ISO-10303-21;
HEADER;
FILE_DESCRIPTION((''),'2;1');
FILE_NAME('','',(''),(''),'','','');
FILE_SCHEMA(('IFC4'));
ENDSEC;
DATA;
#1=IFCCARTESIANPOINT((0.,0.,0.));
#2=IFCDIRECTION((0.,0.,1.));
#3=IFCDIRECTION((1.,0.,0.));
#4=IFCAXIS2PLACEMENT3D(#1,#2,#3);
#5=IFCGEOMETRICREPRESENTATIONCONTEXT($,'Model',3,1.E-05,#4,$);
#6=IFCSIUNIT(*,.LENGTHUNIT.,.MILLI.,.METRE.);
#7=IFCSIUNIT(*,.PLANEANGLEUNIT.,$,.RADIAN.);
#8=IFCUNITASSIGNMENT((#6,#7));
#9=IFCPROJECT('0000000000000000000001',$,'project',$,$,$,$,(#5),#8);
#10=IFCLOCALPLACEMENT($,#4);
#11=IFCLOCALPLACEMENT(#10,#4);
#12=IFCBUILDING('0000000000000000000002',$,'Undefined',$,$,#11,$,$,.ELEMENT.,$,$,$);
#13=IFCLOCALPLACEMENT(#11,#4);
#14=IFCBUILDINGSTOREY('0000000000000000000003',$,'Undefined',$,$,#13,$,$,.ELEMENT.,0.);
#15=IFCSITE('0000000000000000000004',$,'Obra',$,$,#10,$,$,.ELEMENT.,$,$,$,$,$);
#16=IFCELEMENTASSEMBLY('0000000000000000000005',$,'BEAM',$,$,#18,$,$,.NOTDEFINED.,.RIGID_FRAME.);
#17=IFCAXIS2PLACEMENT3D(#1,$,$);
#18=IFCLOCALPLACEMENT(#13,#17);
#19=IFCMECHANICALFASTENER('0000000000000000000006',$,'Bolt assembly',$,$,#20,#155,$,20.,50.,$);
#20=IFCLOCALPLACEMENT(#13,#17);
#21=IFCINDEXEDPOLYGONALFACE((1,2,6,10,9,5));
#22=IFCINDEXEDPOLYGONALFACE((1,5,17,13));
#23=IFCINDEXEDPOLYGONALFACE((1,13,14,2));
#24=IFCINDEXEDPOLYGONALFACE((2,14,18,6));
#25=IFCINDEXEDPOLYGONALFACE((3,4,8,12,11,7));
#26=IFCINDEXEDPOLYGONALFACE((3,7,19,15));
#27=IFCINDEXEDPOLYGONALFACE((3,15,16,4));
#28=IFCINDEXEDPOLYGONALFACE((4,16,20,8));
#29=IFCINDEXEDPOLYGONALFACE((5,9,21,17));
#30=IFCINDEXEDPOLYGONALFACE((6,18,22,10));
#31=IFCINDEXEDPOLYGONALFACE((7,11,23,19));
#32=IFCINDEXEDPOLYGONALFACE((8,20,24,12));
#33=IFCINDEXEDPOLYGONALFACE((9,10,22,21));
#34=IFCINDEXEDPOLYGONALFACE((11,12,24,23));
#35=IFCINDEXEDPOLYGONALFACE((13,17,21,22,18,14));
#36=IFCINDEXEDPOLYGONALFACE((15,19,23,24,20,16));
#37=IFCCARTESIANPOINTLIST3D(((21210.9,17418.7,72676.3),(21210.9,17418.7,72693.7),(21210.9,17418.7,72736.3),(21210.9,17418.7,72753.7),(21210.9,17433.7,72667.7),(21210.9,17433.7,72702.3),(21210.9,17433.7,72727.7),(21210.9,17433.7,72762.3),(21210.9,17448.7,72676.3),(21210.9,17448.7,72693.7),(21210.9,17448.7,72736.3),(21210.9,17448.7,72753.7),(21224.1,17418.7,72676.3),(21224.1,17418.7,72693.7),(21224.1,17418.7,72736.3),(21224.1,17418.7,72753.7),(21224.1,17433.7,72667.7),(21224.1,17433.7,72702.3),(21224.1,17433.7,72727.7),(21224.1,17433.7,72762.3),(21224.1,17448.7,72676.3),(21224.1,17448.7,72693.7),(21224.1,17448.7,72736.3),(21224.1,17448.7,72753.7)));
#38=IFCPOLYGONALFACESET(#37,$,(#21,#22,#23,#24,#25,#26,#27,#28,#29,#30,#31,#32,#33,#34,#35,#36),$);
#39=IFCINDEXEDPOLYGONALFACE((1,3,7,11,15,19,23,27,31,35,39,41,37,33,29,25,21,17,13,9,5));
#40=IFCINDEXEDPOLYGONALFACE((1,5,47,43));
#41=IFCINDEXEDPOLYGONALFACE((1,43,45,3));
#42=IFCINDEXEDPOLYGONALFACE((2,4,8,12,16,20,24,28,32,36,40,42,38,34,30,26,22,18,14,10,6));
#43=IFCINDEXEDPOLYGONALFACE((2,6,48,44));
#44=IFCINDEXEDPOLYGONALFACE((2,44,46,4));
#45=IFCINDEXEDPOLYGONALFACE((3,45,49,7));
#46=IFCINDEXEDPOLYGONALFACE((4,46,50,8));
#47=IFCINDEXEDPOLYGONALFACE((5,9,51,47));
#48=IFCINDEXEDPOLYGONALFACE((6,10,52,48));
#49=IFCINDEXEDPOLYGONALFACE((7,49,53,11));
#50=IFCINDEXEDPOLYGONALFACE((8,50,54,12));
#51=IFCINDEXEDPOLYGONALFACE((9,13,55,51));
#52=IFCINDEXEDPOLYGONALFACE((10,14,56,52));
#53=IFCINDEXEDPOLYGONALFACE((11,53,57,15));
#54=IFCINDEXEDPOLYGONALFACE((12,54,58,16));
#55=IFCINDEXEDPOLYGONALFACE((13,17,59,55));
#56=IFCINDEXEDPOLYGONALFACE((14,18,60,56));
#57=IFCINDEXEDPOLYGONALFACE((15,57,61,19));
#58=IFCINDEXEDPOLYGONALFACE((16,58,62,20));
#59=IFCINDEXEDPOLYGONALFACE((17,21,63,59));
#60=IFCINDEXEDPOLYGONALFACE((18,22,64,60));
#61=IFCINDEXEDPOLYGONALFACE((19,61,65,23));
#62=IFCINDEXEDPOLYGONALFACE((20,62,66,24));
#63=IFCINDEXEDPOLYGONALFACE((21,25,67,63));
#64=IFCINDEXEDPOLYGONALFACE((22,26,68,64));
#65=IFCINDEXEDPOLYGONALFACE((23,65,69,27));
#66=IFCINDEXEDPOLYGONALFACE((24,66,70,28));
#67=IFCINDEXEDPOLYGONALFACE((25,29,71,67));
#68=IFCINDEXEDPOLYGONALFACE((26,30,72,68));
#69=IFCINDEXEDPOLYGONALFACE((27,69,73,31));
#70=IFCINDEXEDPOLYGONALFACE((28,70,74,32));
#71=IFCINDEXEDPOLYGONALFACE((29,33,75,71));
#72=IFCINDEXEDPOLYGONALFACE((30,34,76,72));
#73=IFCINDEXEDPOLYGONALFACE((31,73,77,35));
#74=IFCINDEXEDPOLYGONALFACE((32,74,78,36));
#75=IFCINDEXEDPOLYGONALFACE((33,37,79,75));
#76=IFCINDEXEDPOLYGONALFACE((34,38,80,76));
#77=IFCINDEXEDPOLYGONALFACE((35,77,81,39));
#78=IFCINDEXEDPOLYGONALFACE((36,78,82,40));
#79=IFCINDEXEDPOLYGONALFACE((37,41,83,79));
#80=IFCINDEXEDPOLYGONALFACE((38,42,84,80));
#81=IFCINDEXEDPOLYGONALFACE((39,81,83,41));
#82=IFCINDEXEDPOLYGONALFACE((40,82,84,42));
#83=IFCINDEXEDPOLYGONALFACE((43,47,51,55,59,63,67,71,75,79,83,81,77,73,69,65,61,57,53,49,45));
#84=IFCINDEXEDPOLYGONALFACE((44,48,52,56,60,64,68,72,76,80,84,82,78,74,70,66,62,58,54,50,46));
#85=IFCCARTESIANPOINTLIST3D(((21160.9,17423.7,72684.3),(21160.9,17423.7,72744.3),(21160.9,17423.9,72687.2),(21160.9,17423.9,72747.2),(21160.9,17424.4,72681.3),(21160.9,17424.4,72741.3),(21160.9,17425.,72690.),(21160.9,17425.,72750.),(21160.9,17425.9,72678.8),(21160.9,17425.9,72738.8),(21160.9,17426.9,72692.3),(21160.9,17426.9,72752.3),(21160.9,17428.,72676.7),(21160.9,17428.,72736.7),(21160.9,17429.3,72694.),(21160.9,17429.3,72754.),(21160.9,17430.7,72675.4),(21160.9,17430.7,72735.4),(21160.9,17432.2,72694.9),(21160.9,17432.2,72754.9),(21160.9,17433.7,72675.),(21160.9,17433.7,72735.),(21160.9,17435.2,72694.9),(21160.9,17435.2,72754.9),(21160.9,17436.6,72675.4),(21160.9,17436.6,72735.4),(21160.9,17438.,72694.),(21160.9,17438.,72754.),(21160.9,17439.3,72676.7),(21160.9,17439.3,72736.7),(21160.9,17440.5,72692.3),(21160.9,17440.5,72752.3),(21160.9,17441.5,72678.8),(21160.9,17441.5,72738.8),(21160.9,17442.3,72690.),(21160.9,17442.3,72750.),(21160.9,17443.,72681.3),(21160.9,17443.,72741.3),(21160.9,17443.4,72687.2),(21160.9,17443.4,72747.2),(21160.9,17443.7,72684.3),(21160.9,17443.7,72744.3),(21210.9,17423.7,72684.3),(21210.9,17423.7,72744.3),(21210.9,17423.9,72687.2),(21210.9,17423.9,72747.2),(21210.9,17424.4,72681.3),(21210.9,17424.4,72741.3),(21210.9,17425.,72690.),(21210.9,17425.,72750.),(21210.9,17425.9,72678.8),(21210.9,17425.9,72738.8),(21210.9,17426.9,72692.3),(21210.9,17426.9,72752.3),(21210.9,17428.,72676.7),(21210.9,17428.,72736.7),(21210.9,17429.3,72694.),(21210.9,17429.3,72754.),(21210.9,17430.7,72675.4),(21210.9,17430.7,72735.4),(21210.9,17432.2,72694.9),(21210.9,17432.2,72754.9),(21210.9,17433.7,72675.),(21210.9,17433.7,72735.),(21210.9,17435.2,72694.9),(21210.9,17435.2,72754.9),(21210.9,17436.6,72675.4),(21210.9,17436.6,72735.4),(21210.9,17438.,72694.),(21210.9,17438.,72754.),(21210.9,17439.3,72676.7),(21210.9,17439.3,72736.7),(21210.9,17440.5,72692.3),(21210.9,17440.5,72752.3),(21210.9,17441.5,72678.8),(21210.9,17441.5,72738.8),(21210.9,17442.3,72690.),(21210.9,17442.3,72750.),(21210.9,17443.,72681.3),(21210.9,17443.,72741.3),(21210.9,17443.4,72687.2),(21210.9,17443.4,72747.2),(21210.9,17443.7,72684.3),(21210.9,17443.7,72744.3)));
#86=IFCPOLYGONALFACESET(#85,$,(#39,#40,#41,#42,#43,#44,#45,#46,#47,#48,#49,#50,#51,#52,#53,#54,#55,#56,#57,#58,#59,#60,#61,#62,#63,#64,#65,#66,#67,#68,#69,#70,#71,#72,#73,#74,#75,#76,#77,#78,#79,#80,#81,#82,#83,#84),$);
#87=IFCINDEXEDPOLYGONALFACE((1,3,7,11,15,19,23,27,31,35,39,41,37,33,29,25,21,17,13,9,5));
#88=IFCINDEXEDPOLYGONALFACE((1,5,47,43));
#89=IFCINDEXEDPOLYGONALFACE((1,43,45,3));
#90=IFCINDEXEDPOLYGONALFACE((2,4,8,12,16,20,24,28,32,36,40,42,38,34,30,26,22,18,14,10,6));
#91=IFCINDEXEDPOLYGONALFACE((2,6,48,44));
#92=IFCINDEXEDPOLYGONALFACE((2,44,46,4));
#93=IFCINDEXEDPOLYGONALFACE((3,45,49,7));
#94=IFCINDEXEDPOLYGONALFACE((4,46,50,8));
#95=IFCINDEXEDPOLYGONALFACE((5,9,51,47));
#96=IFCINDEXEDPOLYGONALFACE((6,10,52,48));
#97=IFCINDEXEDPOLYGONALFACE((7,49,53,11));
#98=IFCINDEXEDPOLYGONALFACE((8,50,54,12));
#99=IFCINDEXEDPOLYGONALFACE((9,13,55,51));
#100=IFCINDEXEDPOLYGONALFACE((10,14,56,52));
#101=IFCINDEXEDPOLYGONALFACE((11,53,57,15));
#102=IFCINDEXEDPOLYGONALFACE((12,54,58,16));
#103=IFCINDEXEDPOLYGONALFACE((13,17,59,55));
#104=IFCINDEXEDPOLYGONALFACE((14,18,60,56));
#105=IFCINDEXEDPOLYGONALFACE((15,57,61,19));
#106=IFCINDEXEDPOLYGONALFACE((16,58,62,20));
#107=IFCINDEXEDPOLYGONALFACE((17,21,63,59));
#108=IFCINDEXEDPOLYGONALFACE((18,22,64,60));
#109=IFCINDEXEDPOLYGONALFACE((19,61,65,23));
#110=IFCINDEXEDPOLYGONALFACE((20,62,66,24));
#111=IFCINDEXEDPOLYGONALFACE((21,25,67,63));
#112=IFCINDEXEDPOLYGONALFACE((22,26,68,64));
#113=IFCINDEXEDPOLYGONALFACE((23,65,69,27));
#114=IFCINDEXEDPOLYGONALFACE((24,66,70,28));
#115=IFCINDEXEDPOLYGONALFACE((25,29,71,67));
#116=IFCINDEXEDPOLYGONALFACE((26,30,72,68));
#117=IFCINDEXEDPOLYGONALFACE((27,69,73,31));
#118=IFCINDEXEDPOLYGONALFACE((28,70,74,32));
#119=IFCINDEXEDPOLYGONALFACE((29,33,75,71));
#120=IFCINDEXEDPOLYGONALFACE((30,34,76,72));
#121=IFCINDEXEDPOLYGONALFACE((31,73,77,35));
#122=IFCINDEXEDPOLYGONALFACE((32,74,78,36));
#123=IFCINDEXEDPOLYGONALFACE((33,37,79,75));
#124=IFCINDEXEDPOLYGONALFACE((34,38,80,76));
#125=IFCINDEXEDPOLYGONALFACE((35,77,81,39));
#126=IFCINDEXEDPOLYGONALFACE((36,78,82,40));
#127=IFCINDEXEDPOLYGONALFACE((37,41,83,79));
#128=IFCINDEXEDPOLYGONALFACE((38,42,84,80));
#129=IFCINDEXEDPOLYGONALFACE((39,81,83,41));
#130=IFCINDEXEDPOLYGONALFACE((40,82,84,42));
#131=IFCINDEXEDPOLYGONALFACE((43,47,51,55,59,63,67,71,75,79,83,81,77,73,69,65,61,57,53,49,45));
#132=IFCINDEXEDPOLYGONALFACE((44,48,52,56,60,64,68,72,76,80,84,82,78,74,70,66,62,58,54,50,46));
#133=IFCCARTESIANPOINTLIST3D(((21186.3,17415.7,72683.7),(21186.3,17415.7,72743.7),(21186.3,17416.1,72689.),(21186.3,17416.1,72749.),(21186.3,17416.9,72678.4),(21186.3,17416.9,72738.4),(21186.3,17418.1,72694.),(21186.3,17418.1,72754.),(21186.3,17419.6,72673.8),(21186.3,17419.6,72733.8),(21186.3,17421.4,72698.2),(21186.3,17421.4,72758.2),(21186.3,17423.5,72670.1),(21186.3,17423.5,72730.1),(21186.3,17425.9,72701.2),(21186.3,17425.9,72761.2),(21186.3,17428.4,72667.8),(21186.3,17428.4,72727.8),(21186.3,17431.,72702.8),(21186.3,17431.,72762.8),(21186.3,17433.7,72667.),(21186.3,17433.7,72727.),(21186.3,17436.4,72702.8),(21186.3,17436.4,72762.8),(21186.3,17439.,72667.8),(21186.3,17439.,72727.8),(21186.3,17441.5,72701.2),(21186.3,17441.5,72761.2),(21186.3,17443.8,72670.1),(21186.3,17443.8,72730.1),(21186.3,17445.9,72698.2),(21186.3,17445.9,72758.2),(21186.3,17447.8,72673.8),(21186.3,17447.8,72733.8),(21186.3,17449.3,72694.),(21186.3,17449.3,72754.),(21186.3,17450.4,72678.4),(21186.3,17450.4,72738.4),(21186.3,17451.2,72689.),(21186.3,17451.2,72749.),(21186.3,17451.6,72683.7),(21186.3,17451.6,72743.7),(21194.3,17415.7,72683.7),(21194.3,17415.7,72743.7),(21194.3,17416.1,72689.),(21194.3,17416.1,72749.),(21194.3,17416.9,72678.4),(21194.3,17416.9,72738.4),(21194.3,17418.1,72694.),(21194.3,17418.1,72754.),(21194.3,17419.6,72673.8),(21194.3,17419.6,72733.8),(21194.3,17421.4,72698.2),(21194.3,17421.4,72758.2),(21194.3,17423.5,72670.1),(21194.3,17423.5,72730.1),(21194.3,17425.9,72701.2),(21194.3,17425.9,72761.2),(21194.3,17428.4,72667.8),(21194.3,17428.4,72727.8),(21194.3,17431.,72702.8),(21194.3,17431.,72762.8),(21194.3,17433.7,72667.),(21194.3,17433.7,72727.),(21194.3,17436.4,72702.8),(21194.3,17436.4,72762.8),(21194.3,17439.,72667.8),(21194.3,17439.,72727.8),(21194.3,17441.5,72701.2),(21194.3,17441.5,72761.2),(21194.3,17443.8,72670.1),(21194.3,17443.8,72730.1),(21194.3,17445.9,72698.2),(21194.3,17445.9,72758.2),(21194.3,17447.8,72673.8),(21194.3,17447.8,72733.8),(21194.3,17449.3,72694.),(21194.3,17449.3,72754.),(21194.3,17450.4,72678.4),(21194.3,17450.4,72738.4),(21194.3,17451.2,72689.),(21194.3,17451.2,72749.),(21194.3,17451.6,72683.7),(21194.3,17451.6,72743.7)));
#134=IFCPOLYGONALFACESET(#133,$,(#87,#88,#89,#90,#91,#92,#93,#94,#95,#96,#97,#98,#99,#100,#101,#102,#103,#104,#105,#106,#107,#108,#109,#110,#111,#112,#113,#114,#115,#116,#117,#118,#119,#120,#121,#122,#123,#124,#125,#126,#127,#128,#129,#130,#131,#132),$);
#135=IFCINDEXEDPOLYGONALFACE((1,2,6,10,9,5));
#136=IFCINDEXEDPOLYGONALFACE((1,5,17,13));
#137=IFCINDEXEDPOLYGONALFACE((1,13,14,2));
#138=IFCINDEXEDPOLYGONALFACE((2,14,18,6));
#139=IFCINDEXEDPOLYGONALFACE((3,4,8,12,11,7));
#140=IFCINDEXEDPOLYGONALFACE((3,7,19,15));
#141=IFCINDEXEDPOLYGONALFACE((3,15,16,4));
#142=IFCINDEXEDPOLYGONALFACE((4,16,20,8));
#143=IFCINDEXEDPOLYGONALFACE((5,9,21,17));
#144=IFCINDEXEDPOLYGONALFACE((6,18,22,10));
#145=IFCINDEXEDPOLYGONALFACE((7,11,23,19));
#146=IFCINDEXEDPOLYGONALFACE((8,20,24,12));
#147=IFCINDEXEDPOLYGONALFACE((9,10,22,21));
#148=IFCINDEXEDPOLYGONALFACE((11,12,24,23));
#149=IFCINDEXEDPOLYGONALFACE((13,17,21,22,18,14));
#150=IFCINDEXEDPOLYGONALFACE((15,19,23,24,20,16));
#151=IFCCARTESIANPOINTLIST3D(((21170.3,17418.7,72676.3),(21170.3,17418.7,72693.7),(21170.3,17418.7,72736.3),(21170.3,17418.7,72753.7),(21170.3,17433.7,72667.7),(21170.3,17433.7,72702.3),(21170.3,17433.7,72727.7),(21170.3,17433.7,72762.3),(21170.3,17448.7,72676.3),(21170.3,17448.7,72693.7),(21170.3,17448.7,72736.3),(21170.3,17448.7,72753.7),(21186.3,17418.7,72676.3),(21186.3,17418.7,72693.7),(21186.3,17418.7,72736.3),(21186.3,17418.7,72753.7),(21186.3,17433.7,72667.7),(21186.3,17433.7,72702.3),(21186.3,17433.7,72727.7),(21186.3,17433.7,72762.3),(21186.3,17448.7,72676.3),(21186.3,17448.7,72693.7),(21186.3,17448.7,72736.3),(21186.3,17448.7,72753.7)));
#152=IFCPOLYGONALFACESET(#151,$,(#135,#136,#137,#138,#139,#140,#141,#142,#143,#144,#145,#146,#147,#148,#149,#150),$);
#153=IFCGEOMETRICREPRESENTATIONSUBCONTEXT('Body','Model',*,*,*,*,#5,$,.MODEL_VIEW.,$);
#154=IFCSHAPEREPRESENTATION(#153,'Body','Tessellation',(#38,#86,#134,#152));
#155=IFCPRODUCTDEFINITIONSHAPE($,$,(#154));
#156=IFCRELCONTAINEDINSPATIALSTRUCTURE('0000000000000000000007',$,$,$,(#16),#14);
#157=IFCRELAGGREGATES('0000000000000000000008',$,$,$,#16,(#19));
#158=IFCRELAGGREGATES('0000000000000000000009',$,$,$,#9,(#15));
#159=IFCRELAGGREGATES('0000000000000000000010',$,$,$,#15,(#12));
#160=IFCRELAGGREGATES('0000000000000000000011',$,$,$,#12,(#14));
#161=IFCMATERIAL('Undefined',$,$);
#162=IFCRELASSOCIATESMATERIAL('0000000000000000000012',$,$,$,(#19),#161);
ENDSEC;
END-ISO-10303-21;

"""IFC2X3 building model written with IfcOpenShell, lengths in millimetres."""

from ifc_helpers import new_model, si_unit, frame, origin_with_axes, origin_2d_with_axis, place, context, subcontext, project, spatial, polyline, circle, outline, extrude, source, transform, mapped, material, element, aggregate, save


model = new_model("IFC2X3")

# Units and contexts
model_context = context("Model", 3, precision=1e-05, world=origin_with_axes())
body_context = subcontext(model_context, "Body", "Model", "MODEL_VIEW")
ifc_project = project(units=[si_unit("LENGTHUNIT", "METRE", prefix="MILLI"), si_unit("PLANEANGLEUNIT", "RADIAN")], contexts=[model_context])

# Site, building, storey
site_placement = place(None, origin_with_axes())
site = spatial("IfcSite", under=ifc_project, at=site_placement, Name="Obra", CompositionType="ELEMENT")
building_placement = place(site_placement, origin_with_axes())
building = spatial("IfcBuilding", under=site, at=building_placement, Name="Undefined", CompositionType="ELEMENT")
storey_placement = place(building_placement, origin_with_axes())
storey = spatial("IfcBuildingStorey", under=building, at=storey_placement, Name="Undefined", CompositionType="ELEMENT", Elevation=0.0)

# Shared definitions
ifc_material = material(Name="Undefined")

# Element assembly, mechanical fastener
assembly_1_placement = place(storey_placement, origin_with_axes())
assembly_1 = element("IfcElementAssembly", 1, at=assembly_1_placement, inside=storey, Name="BEAM", AssemblyPlace="NOTDEFINED", PredefinedType="RIGID_FRAME")
shared_shape_1 = source(origin_with_axes(), body_context, "Body", "SweptSolid", [
    extrude(outline(polyline([(17.3, 0.0), (8.7, 15.0), (-8.7, 15.0), (-17.3, 0.0), (-8.7, -15.0), (8.7, -15.0), (17.3, 0.0)])), frame((0.0, -26.5, 0.0), z_axis=(0.0, 1.0, 0.0), x_axis=(1.0, 0.0, 0.0)), (0.0, 0.0, 1.0), 13.2),
    extrude(circle(Radius=10.0, at=origin_2d_with_axis()), frame((0.0, -13.3, 0.0), z_axis=(0.0, 1.0, 0.0), x_axis=(1.0, 0.0, 0.0)), (0.0, 0.0, 1.0), 50.0),
    extrude(circle(Radius=18.0, at=origin_2d_with_axis()), frame((0.0, 3.3, 0.0), z_axis=(0.0, 1.0, 0.0), x_axis=(1.0, 0.0, 0.0)), (0.0, 0.0, 1.0), 8.0),
    extrude(outline(polyline([(17.3, 0.0), (8.7, 15.0), (-8.7, 15.0), (-17.3, 0.0), (-8.7, -15.0), (8.7, -15.0), (17.3, 0.0)])), frame((0.0, 11.3, 0.0), z_axis=(0.0, 1.0, 0.0), x_axis=(1.0, 0.0, 0.0)), (0.0, 0.0, 1.0), 16.0),
])
mechanical_fastener_1_placement = place(assembly_1_placement, frame((21197.6, 17393.7, 72850.0), z_axis=(0.0, 1.0, 0.0), x_axis=(0.0, 0.0, -1.0)))
mechanical_fastener_1 = element("IfcMechanicalFastener", 2, at=mechanical_fastener_1_placement, material=ifc_material, Name="Bolt assembly", NominalDiameter=20.0, NominalLength=50.0, context=body_context, shape_type="MappedRepresentation", body=[
    mapped(shared_shape_1, transform((105.0, 0.0, 40.0))),
    mapped(shared_shape_1, transform((165.0, 0.0, 40.0))),
])
aggregate(assembly_1, [mechanical_fastener_1])

save(model, "model.ifc")
